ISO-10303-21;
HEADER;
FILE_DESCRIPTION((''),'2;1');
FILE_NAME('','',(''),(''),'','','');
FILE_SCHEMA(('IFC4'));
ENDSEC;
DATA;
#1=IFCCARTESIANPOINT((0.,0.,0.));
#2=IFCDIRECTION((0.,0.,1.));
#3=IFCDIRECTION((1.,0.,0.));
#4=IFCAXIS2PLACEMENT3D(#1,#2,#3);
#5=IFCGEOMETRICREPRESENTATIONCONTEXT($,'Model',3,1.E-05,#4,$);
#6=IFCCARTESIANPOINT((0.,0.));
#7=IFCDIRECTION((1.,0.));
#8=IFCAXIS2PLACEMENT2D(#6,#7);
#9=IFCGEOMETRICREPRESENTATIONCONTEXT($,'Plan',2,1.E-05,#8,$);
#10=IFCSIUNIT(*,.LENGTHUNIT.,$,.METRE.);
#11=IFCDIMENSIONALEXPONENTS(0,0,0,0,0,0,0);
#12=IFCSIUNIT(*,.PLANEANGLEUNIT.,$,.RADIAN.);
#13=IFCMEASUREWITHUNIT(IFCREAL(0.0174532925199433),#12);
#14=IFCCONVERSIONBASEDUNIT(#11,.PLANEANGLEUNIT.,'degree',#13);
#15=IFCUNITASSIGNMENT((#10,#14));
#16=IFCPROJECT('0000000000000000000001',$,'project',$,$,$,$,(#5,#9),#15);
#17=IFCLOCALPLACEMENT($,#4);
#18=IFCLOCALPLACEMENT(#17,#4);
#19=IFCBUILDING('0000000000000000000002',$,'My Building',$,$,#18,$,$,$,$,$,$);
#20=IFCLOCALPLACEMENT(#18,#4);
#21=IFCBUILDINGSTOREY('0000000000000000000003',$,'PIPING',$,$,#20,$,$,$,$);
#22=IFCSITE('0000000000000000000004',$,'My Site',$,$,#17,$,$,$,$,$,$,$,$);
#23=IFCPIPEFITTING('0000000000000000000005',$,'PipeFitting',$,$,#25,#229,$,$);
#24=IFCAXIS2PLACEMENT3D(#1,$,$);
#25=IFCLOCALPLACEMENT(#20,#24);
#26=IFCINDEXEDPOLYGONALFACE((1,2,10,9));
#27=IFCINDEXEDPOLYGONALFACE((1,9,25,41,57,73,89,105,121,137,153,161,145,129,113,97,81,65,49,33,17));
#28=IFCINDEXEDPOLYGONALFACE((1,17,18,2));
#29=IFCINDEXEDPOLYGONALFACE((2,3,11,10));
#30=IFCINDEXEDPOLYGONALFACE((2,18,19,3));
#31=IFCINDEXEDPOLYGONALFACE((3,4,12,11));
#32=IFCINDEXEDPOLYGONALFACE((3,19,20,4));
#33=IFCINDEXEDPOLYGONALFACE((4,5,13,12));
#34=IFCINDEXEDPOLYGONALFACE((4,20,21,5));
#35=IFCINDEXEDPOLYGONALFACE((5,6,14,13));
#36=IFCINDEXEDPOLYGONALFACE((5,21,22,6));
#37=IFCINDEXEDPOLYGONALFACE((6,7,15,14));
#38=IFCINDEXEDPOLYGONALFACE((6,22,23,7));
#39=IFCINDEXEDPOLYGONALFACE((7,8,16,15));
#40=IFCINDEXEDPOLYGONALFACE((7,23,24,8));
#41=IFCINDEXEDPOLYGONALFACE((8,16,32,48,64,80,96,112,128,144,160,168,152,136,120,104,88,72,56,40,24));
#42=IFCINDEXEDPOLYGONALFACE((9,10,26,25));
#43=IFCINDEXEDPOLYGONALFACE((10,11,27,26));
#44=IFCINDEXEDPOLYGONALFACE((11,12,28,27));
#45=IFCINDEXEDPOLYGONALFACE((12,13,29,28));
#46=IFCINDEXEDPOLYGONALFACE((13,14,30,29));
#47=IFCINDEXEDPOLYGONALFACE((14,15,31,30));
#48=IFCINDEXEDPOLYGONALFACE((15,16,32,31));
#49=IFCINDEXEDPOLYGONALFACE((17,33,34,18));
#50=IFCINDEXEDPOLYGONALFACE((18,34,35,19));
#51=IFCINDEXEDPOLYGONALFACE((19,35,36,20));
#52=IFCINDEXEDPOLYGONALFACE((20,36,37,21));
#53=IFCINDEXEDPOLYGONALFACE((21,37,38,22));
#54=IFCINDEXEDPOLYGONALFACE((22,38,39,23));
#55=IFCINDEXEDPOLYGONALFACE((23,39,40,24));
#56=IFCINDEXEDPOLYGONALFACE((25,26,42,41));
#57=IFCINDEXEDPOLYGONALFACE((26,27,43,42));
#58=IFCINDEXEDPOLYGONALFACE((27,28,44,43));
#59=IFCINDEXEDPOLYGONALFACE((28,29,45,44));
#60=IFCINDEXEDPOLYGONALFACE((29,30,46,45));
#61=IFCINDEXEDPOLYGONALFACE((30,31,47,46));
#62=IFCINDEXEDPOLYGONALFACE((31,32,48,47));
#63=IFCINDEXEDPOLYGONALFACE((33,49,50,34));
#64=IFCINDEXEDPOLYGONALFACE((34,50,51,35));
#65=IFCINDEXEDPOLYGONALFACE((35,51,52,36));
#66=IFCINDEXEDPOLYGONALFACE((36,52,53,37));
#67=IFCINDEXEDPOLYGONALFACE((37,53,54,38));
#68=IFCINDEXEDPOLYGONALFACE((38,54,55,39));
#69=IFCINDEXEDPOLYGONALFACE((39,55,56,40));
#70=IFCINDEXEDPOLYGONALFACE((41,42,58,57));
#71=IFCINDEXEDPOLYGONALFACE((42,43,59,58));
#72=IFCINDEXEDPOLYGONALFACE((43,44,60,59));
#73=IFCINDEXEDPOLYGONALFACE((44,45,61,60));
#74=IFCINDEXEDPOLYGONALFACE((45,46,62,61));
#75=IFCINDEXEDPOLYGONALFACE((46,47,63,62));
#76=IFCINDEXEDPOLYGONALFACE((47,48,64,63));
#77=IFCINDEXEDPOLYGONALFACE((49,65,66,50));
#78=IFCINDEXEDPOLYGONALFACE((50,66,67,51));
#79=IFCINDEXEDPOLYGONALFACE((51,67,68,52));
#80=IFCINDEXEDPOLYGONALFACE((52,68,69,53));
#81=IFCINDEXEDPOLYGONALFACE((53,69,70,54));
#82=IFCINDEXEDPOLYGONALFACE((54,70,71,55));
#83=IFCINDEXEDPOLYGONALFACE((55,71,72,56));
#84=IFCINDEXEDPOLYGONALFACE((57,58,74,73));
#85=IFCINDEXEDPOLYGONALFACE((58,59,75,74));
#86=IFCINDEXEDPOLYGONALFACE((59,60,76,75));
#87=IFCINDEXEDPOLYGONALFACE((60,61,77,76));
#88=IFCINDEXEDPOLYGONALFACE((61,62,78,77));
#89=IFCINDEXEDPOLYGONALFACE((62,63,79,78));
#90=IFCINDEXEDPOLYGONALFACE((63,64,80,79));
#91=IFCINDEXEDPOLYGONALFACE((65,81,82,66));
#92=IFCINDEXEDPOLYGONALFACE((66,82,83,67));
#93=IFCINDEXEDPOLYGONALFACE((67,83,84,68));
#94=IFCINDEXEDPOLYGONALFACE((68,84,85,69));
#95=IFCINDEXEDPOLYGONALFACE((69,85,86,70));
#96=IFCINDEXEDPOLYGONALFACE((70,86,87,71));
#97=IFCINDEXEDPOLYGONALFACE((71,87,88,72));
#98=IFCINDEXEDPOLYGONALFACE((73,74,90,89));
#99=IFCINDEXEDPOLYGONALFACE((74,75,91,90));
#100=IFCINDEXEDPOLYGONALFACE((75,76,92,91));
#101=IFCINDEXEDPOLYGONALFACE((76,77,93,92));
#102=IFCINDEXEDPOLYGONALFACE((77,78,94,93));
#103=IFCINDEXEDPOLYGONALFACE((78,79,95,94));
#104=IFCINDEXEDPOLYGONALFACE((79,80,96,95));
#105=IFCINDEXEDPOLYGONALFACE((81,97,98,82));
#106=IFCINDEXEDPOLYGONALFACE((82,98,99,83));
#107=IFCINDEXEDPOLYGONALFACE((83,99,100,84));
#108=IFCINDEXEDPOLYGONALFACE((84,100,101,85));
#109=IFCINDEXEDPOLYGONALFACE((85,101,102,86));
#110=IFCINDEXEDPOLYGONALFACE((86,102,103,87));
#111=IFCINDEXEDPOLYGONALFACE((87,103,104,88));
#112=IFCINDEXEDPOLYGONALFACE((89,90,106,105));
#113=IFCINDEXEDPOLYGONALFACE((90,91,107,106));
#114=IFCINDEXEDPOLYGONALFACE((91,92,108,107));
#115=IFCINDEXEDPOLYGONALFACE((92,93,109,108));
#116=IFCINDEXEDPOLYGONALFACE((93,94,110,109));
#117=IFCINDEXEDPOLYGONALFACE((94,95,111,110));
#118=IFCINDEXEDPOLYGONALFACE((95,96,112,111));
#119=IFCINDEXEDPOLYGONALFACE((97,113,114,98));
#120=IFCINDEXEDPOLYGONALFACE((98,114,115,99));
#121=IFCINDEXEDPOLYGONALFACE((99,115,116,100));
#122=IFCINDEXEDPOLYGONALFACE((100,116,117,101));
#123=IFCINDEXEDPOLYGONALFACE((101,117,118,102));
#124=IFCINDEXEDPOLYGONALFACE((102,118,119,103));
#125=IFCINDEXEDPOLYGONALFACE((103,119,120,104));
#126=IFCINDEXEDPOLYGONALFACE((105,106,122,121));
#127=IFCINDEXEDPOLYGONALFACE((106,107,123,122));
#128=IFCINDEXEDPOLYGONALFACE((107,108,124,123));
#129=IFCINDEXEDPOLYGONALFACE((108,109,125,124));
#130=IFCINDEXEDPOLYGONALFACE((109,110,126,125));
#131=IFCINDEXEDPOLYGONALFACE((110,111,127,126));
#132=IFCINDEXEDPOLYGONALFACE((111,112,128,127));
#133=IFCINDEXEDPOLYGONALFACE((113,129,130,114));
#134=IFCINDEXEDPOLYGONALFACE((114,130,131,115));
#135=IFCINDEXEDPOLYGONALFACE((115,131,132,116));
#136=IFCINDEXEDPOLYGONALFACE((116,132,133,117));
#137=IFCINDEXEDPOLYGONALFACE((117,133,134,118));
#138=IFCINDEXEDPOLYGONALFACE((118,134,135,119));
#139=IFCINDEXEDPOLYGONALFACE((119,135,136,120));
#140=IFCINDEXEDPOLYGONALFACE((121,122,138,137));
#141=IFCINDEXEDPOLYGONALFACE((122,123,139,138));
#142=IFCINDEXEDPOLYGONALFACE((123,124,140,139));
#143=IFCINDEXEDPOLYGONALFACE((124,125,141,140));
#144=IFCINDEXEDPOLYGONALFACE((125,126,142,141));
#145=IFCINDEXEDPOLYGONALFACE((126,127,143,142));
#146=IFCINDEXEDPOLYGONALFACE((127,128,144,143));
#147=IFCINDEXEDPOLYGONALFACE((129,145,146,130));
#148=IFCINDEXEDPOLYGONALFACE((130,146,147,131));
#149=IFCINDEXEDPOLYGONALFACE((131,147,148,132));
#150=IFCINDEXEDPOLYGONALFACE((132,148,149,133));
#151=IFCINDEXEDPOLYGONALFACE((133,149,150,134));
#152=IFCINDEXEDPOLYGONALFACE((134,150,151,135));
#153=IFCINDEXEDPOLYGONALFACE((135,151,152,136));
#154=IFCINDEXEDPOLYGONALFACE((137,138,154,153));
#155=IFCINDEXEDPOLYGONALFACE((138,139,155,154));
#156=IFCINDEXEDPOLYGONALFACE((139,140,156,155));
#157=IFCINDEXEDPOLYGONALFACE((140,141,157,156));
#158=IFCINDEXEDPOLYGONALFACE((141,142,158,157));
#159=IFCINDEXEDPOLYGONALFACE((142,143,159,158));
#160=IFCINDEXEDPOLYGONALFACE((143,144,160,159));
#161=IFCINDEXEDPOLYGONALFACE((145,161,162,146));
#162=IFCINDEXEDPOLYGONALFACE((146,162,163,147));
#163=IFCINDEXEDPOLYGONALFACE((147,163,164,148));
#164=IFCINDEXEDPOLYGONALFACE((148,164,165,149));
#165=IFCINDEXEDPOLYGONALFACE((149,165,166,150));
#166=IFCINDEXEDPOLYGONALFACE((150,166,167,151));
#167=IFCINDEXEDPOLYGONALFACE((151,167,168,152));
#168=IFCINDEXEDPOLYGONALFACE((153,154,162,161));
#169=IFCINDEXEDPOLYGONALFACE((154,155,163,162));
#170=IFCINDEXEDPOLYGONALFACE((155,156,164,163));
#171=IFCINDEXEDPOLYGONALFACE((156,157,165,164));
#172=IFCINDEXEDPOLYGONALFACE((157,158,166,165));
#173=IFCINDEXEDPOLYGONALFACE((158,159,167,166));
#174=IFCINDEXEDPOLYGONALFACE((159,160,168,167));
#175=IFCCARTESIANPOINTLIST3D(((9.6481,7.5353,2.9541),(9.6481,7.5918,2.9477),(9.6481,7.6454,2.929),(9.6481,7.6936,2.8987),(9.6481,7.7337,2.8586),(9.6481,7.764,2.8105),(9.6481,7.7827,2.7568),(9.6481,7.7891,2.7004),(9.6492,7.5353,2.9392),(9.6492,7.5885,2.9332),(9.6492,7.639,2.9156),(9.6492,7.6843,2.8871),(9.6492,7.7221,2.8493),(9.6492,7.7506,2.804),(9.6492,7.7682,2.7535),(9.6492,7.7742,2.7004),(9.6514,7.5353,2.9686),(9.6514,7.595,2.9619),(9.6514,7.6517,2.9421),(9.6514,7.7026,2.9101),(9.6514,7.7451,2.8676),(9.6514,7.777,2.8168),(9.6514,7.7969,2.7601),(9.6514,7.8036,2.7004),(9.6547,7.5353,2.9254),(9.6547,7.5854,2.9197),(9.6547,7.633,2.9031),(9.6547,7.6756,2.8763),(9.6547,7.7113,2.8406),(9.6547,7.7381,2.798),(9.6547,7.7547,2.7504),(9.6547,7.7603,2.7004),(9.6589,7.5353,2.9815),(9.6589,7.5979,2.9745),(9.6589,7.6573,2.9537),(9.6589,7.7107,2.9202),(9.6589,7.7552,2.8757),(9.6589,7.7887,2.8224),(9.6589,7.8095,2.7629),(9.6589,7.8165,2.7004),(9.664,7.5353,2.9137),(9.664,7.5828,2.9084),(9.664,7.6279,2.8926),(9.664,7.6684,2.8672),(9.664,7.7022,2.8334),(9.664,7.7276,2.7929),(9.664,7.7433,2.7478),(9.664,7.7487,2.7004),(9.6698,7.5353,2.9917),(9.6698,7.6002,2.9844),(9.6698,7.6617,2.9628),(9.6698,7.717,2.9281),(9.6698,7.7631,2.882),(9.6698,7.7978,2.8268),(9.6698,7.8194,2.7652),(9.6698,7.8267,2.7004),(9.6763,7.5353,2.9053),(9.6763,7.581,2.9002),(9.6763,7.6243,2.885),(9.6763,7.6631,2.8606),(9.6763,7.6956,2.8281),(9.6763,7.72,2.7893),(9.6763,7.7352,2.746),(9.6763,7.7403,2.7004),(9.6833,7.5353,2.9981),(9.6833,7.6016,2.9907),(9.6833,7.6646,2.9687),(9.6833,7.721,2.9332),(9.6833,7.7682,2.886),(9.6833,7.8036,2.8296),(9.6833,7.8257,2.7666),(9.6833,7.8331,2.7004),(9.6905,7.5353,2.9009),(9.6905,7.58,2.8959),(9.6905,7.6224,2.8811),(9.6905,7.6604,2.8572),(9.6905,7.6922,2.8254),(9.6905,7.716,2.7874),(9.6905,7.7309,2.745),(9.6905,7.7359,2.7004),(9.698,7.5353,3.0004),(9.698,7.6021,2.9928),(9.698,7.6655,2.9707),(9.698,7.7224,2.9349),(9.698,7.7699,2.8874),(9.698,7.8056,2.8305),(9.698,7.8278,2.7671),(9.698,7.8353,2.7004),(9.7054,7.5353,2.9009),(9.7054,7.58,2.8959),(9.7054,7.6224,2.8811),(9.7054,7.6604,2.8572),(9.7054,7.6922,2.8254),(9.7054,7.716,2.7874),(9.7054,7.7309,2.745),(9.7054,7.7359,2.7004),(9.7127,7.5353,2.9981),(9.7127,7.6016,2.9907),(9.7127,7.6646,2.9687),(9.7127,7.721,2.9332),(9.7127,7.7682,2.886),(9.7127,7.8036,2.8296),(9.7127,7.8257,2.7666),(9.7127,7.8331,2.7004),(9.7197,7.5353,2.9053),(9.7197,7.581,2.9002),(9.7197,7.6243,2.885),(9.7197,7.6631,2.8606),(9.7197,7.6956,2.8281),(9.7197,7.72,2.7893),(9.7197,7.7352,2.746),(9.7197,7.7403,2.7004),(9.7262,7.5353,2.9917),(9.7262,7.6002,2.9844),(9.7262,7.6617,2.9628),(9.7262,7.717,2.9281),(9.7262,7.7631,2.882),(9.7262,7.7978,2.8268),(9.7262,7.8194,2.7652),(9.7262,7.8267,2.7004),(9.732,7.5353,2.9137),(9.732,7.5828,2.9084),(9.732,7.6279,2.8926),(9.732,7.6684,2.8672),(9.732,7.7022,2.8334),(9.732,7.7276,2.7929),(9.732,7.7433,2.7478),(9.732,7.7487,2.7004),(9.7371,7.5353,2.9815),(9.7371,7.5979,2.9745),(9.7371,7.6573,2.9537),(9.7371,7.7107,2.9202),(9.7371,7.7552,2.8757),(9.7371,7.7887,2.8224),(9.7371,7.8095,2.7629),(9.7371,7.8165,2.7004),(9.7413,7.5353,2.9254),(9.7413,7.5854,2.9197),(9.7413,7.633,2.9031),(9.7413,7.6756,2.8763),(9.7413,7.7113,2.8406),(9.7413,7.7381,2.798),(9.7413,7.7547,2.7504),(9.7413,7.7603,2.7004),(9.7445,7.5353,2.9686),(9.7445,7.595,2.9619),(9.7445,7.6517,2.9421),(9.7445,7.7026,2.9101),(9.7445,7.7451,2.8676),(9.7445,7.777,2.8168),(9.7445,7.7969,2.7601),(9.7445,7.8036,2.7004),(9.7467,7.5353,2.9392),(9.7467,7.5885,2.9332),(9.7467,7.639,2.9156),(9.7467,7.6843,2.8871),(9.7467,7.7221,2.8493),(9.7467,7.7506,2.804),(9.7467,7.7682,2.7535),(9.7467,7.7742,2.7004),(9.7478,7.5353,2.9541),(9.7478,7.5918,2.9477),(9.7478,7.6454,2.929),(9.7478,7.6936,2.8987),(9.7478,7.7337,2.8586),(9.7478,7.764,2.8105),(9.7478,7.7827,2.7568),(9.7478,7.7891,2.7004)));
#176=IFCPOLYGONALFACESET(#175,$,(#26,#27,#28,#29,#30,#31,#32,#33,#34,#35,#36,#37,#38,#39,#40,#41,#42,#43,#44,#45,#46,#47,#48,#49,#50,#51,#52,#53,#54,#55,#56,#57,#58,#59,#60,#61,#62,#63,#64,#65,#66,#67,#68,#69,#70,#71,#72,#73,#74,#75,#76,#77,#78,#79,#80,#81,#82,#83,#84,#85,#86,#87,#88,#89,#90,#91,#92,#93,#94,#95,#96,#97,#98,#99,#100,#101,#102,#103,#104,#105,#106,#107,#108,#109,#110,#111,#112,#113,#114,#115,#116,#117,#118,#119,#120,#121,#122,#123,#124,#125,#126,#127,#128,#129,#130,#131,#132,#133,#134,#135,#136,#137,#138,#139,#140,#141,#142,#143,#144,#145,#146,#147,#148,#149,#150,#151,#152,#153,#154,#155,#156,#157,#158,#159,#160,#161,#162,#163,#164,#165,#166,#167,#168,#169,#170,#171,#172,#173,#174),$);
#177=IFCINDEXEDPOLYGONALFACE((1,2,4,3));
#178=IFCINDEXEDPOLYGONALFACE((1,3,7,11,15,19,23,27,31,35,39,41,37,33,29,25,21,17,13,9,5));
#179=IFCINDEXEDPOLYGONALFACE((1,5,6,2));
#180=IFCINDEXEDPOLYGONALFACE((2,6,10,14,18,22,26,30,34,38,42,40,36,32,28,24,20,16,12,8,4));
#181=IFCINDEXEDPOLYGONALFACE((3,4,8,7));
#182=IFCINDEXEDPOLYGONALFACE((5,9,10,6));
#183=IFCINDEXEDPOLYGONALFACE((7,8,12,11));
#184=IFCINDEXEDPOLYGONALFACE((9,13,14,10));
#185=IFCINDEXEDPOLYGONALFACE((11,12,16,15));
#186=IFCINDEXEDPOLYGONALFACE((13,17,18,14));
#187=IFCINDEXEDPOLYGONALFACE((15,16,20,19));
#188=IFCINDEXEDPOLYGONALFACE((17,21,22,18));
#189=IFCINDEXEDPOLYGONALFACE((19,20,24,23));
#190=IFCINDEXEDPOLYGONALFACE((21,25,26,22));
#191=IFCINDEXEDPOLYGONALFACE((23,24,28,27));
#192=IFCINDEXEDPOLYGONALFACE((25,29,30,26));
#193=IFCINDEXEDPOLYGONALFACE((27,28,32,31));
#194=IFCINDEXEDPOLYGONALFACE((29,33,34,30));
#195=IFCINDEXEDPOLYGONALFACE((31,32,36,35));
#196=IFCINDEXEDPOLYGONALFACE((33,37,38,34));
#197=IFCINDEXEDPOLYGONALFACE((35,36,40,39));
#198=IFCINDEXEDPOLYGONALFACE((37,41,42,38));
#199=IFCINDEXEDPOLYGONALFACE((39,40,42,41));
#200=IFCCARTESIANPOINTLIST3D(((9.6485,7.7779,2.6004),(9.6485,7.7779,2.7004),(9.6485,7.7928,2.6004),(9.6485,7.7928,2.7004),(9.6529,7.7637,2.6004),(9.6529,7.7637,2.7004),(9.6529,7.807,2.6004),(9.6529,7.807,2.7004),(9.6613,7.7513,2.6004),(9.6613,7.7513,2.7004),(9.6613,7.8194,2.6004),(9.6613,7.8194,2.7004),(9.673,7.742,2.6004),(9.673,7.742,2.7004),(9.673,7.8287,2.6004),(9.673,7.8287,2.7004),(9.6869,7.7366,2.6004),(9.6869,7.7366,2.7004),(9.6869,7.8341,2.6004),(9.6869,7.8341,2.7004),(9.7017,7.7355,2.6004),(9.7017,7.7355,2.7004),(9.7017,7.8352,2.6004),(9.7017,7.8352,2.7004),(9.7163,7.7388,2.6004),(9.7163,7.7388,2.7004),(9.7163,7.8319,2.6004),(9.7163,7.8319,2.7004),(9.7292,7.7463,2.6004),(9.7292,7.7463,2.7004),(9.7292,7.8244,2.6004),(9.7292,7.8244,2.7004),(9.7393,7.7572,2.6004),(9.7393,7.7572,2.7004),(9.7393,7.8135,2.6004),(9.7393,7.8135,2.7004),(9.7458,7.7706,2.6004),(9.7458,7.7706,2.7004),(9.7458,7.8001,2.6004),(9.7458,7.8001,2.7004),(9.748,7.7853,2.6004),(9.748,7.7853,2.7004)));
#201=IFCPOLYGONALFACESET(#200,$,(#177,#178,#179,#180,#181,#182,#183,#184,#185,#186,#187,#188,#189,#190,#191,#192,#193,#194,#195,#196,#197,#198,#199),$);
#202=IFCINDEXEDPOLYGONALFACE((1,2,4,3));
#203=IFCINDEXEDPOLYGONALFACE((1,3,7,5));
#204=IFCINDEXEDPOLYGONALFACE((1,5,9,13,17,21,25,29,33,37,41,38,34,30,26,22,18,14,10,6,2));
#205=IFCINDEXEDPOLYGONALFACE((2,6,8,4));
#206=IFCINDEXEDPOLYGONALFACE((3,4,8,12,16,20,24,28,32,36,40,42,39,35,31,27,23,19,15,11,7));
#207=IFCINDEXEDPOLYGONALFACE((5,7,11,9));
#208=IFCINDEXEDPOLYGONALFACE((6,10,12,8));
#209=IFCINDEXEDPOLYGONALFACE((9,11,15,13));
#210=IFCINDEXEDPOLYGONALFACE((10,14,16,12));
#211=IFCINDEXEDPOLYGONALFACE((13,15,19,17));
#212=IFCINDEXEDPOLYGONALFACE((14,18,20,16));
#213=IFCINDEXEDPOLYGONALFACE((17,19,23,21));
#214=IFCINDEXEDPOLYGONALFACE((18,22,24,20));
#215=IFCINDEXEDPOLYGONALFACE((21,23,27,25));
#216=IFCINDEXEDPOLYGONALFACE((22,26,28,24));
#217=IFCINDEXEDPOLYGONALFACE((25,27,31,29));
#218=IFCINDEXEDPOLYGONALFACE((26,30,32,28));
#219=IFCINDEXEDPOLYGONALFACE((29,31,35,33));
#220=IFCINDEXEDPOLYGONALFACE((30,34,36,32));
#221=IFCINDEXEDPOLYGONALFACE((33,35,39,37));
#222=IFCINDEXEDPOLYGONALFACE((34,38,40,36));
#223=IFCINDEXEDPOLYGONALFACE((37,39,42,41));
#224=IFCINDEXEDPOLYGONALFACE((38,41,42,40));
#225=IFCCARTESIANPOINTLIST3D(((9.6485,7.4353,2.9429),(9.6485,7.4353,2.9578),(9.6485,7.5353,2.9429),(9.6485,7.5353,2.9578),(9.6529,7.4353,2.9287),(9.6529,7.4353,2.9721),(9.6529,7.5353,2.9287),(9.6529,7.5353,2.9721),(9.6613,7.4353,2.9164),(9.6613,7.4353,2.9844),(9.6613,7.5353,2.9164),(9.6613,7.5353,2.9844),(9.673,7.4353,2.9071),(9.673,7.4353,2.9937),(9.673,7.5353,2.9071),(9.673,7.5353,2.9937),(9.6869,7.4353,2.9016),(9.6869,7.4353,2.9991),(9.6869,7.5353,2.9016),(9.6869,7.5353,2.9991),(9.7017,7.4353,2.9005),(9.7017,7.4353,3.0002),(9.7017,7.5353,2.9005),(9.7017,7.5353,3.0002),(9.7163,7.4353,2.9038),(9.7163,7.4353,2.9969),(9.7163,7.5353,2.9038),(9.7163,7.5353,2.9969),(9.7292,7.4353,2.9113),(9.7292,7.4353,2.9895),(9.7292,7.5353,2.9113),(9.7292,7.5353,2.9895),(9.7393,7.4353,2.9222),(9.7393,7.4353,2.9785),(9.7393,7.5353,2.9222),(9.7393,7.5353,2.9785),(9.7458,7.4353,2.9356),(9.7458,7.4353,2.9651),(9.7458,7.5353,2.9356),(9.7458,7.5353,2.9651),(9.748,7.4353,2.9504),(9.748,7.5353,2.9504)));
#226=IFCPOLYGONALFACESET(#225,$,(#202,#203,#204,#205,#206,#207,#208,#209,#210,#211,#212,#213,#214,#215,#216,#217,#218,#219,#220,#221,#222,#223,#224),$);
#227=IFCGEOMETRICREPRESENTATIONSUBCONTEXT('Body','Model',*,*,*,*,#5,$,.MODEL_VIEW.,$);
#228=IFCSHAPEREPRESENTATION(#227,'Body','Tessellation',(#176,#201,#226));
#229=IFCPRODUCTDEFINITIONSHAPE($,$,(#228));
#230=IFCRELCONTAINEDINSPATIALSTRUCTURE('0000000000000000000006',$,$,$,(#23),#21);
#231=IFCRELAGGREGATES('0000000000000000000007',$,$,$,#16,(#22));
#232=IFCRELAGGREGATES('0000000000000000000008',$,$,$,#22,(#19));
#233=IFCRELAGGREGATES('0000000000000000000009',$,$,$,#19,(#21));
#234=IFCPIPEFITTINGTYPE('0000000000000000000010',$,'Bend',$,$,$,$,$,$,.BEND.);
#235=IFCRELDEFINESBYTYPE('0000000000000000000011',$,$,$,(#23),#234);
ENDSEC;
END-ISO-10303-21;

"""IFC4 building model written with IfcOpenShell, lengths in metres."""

from ifc_helpers import new_model, entity, si_unit, converted_unit, frame, origin_with_axes, origin_2d_with_axis, place, context, subcontext, project, spatial, circle, extrude, source, transform, mapped, type_object, type_shapes, element, save


model = new_model("IFC4")

# Units and contexts
model_context = context("Model", 3, precision=1e-05, world=origin_with_axes())
plan_context = context("Plan", 2, precision=1e-05, world=origin_2d_with_axis())
body_context = subcontext(model_context, "Body", "Model", "MODEL_VIEW")
ifc_project = project(units=[si_unit("LENGTHUNIT", "METRE"), converted_unit("PLANEANGLEUNIT", "degree", entity("IfcReal", 0.0174532925199433), si_unit("PLANEANGLEUNIT", "RADIAN"), dimensions=[0, 0, 0, 0, 0, 0, 0])], contexts=[model_context, plan_context])

# Site, building, storey
site_placement = place(None, origin_with_axes())
site = spatial("IfcSite", under=ifc_project, at=site_placement, Name="My Site")
building_placement = place(site_placement, origin_with_axes())
building = spatial("IfcBuilding", under=site, at=building_placement, Name="My Building")
storey_placement = place(building_placement, origin_with_axes())
storey = spatial("IfcBuildingStorey", under=building, at=storey_placement, Name="PIPING")

# Pipe fitting
pipe_fitting_type_1 = type_object("IfcPipeFittingType", Name="Bend", PredefinedType="BEND")
shared_shape = source(origin_with_axes(), body_context, "Body", "SolidModel", [
    entity("IfcSweptDiskSolid", entity("IfcIndexedPolyCurve", entity("IfcCartesianPointList3D", [[0.0, 0.0, -0.1], [0.0, 0.0732, -0.2768], [0.0, 0.25, -0.35]]), [entity("IfcArcIndex", [1, 2, 3])]), 0.05),
    extrude(circle(Radius=0.05), origin_with_axes(), (0.0, 0.0, -1.0), 0.1),
    extrude(circle(Radius=0.05), frame((0.0, 0.25, -0.35), z_axis=(0.0, 1.0, 0.0), x_axis=(1.0, 0.0, 0.0)), (0.0, 0.0, 1.0), 0.1),
])
type_shapes(pipe_fitting_type_1, [shared_shape])
for number, where, z_axis, x_axis, name in (
    (1, (9.698, 7.7853, 2.6004), (0.0, 0.0, -1.0), (1.0, 0.0, 0.0), "PipeFitting"),
):
    element("IfcPipeFitting", number, at=place(storey_placement, frame(where, z_axis=z_axis, x_axis=x_axis)), inside=storey, type_object=pipe_fitting_type_1, Name=name, context=body_context, shape_type="MappedRepresentation", body=[
        mapped(shared_shape, transform((0.0, 0.0, 0.0), x_axis=(1.0, 0.0, 0.0), y_axis=(0.0, 1.0, 0.0), z_axis=(0.0, 0.0, 1.0), scale=1.0)),
    ])

save(model, "model.ifc")
